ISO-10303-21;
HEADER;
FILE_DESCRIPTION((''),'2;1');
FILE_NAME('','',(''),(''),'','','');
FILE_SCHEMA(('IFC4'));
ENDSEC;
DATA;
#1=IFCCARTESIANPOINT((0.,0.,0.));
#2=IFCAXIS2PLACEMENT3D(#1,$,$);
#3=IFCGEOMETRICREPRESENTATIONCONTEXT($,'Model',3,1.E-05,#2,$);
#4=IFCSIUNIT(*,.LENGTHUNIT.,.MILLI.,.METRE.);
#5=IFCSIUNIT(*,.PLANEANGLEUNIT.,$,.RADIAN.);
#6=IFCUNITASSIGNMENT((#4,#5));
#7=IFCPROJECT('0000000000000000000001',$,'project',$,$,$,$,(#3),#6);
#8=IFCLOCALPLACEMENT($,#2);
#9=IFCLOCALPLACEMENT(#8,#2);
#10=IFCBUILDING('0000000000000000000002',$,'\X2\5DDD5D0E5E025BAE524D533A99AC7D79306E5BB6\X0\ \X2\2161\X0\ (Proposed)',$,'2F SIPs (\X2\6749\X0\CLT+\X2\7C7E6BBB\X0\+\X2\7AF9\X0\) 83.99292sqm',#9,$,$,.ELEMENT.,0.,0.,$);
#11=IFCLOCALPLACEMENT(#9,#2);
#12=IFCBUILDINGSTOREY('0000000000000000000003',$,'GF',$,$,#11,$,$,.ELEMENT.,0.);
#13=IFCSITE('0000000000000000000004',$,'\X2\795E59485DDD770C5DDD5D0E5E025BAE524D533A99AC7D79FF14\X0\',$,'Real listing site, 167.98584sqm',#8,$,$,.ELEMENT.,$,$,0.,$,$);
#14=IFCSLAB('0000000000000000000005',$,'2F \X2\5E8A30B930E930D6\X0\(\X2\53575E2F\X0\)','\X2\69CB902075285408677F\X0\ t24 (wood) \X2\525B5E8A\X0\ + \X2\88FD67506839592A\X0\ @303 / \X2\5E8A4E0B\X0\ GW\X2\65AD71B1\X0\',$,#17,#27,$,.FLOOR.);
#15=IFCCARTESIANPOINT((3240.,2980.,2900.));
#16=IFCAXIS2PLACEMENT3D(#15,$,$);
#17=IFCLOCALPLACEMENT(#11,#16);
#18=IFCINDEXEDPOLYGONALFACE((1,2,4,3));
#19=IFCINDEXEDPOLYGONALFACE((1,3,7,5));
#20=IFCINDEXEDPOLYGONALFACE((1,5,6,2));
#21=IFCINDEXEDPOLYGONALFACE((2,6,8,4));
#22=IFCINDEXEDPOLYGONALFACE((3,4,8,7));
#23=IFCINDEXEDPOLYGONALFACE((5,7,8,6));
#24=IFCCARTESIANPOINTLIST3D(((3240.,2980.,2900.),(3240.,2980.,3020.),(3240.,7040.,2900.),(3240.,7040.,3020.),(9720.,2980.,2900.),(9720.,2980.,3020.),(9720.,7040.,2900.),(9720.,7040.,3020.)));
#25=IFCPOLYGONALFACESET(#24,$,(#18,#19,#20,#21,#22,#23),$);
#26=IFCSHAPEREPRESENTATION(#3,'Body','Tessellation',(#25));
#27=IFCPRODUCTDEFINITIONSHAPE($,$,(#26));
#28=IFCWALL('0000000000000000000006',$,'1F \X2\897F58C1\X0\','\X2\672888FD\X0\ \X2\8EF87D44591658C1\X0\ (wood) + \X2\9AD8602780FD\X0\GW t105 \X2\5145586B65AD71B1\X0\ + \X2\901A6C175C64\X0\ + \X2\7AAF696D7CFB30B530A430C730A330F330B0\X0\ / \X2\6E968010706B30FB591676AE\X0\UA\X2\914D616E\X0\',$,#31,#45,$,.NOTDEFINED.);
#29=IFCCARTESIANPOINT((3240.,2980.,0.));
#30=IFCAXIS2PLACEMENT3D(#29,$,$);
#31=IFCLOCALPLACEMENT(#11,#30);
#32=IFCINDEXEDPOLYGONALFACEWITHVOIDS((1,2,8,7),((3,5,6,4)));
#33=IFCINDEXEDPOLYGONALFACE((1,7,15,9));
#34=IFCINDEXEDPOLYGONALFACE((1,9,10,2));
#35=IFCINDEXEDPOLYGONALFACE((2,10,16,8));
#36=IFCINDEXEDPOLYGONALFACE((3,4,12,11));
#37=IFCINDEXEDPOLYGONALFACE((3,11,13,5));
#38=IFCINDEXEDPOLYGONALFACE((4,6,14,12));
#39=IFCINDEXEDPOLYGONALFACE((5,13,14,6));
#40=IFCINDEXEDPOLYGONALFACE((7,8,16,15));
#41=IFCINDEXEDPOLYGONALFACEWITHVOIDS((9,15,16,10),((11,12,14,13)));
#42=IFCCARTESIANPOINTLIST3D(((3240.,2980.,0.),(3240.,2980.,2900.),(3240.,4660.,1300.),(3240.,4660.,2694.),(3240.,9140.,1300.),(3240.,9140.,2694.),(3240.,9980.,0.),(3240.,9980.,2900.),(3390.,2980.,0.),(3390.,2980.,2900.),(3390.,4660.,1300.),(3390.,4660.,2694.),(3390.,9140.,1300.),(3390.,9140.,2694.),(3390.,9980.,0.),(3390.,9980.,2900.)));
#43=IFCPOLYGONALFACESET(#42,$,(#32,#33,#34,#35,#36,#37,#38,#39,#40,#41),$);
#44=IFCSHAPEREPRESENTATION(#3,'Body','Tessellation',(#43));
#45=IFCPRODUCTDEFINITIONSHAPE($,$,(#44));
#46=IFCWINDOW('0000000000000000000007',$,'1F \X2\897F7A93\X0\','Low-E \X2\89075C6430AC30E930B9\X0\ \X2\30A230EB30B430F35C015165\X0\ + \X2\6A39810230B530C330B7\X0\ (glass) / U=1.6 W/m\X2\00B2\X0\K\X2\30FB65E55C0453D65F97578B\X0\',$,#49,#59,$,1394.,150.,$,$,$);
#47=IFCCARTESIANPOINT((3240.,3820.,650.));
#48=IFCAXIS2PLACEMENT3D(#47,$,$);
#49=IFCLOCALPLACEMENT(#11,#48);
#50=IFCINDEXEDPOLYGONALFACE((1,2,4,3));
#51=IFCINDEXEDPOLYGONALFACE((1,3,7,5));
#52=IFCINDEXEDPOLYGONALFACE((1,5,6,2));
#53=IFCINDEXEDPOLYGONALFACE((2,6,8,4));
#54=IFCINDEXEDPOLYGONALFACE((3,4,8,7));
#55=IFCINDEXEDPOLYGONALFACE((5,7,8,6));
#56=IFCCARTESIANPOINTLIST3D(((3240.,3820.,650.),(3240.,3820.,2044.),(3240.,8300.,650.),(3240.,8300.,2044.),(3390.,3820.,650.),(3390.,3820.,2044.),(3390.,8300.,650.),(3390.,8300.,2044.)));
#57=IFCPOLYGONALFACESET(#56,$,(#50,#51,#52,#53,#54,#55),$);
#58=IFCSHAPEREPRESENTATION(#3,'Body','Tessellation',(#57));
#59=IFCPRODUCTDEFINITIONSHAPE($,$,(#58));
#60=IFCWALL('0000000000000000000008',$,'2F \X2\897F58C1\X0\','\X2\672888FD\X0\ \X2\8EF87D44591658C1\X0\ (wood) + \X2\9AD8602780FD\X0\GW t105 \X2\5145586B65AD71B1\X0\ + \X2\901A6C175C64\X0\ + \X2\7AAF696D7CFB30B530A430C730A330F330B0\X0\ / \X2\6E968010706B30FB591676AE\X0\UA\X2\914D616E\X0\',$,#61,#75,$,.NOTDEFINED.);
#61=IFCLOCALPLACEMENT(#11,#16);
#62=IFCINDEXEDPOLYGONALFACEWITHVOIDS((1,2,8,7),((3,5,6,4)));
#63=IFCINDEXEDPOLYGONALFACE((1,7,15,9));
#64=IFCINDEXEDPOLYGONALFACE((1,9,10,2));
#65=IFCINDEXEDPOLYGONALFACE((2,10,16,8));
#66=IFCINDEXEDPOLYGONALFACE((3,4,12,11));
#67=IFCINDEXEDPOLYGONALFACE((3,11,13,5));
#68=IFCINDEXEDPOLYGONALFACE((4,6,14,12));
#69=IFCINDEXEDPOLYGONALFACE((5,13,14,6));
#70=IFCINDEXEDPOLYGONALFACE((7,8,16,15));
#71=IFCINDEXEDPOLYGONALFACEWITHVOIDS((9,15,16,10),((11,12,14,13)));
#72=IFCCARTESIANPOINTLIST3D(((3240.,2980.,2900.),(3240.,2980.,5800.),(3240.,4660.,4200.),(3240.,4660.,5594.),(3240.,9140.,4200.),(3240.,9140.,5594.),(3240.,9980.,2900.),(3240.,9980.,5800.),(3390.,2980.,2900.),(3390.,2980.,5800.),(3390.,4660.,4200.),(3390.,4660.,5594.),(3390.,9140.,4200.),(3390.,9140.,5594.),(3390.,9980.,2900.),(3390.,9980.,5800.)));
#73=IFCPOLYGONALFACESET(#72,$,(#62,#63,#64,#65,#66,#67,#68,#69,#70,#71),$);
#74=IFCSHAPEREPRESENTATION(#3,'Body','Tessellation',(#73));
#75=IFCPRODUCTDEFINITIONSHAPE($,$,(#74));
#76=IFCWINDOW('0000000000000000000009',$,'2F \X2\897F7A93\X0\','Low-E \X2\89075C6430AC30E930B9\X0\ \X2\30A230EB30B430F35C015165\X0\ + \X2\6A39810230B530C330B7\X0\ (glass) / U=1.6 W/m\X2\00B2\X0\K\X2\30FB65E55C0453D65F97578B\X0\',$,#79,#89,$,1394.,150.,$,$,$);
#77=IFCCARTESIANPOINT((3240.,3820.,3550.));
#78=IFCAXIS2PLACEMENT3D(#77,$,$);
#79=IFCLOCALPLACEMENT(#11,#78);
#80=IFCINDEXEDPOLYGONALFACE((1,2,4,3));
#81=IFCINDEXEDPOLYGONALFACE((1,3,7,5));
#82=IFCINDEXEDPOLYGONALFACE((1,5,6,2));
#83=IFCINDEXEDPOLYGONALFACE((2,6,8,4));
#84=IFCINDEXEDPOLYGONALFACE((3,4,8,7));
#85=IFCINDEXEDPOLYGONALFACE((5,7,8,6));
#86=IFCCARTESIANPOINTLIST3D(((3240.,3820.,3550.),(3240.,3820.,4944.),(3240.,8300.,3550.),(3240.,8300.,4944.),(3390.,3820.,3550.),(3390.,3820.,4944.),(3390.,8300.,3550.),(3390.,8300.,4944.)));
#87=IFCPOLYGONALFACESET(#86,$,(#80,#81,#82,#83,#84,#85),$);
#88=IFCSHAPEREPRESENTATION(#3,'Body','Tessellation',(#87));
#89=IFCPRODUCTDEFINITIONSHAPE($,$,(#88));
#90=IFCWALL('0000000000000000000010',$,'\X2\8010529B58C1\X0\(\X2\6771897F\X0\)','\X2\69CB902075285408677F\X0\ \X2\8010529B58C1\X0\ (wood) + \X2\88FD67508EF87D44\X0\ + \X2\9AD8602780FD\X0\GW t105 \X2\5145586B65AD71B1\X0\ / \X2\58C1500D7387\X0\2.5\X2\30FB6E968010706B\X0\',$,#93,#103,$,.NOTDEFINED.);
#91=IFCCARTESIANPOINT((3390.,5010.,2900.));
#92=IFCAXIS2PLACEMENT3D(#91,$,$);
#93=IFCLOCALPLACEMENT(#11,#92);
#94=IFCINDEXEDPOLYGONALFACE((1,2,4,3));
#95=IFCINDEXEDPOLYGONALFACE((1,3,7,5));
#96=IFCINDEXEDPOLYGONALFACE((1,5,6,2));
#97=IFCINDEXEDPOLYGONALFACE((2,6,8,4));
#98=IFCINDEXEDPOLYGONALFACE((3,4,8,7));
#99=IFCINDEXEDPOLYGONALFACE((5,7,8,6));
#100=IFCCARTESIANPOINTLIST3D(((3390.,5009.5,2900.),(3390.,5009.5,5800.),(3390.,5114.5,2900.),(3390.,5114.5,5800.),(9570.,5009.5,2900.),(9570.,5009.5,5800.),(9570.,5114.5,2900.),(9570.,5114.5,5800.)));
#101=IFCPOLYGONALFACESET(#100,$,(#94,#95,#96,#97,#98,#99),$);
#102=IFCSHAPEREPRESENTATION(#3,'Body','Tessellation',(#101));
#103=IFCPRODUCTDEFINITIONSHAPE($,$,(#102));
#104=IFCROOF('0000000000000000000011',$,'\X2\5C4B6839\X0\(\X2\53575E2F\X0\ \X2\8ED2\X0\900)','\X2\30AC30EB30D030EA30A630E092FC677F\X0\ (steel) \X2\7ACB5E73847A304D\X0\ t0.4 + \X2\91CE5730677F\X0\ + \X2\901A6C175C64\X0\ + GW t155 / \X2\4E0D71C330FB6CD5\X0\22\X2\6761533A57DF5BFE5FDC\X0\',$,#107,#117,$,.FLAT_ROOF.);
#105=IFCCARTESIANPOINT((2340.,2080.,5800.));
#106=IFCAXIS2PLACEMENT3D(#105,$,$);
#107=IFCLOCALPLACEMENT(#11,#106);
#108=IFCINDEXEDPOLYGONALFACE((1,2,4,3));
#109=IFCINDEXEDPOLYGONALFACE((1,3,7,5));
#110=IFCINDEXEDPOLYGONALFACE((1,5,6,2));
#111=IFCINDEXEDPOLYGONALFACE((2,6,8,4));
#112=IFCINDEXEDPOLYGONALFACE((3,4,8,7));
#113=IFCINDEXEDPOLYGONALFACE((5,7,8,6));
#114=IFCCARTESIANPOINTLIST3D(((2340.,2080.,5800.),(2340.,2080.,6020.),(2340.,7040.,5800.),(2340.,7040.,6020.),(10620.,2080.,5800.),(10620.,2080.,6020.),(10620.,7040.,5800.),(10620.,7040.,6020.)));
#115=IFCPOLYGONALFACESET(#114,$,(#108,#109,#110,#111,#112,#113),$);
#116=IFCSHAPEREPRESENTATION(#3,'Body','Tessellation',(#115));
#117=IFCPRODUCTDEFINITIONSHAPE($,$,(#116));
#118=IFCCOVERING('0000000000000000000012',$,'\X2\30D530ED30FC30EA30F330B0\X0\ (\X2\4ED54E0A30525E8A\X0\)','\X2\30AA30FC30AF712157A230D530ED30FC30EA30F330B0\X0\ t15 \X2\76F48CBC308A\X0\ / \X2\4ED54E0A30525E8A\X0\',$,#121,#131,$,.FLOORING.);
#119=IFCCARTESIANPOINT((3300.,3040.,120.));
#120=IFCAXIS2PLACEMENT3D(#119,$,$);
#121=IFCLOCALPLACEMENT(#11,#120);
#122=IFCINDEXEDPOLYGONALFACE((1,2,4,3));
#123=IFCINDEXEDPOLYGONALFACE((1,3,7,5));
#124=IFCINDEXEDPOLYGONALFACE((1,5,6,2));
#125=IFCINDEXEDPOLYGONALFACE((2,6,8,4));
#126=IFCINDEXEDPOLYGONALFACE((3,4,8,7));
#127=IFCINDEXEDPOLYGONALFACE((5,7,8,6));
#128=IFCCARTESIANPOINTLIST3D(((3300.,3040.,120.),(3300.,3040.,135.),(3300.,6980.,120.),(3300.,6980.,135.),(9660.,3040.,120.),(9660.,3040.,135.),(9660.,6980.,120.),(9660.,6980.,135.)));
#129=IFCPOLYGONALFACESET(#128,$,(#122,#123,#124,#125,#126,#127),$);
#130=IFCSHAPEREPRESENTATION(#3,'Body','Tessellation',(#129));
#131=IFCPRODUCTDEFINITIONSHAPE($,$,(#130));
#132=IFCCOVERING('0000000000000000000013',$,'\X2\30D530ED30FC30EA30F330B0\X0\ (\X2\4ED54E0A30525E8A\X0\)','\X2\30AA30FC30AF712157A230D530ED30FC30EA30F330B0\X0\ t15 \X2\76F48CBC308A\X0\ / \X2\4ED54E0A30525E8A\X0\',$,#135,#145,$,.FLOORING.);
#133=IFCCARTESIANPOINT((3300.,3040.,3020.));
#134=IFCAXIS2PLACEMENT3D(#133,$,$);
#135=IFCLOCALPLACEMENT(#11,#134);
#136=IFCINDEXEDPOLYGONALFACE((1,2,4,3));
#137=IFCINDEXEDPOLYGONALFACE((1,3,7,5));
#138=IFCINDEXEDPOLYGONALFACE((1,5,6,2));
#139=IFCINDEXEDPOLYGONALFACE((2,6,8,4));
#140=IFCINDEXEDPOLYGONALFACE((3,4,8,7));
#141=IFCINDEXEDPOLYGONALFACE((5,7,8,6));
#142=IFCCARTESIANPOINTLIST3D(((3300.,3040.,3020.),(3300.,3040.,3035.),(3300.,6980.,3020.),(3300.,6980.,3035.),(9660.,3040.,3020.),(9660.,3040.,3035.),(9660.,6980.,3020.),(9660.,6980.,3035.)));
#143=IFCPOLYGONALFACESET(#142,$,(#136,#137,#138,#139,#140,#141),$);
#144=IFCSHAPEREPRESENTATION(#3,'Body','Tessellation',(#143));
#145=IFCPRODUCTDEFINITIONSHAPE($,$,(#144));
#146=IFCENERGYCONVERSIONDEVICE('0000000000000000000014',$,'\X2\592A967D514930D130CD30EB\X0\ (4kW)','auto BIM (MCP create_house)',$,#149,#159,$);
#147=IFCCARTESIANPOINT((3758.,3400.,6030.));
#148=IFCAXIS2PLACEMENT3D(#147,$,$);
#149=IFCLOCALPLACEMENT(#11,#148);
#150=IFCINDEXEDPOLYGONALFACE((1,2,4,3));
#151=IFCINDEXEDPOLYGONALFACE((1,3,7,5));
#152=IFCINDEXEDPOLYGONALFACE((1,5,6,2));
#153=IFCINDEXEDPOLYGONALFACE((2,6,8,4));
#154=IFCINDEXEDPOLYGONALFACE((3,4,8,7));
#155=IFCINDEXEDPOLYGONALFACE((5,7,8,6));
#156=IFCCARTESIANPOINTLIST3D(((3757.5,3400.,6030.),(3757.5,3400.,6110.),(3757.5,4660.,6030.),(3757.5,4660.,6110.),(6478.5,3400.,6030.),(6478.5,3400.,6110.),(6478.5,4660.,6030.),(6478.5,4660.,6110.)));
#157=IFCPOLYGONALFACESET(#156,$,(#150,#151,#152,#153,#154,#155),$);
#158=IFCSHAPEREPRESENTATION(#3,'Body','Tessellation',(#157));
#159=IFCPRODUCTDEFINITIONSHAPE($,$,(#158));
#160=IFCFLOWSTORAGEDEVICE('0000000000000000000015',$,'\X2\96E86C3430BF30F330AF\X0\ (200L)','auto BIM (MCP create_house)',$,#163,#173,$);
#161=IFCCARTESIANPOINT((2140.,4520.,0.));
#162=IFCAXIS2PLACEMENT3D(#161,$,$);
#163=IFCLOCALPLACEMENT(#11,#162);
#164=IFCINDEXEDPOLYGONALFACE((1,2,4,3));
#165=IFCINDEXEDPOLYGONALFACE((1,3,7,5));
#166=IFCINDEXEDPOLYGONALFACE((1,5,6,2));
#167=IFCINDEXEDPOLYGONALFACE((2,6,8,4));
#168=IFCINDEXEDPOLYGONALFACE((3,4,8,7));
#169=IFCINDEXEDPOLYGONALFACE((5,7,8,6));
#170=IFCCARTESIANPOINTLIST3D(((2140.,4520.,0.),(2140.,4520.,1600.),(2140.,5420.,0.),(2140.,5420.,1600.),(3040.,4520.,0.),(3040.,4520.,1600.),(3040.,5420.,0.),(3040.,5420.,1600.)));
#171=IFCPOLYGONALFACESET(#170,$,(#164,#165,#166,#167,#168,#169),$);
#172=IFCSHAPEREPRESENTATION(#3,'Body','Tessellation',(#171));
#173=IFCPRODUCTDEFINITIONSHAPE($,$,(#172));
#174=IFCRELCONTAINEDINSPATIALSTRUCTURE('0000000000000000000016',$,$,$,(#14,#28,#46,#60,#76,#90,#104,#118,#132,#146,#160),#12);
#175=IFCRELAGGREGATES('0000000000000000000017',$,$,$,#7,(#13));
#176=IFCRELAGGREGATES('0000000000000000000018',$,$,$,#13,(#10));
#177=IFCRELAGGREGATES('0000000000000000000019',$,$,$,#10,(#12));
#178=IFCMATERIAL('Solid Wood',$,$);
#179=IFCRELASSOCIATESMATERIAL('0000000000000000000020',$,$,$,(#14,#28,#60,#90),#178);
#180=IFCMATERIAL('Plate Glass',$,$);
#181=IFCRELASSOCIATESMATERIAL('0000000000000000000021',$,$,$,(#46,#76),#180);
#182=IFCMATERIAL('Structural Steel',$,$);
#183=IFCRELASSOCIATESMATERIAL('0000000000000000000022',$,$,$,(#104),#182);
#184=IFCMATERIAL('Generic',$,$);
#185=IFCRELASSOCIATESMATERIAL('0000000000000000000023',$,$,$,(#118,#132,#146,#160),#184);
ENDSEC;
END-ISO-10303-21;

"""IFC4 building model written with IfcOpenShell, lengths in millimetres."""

from ifc_helpers import new_model, si_unit, frame, frame_2d, origin, place, context, project, spatial, rectangle, extrude, material, element, fill, save


model = new_model("IFC4")

# Units and contexts
model_context = context("Model", 3, precision=1e-05, world=origin())
ifc_project = project(units=[si_unit("LENGTHUNIT", "METRE", prefix="MILLI"), si_unit("PLANEANGLEUNIT", "RADIAN")], contexts=[model_context])

# Site, building, storey
site_placement = place(None, origin())
site = spatial("IfcSite", under=ifc_project, at=site_placement, Name="神奈川県川崎市宮前区馬絹４", ObjectType="Real listing site, 167.98584sqm", CompositionType="ELEMENT", RefElevation=0.0)
building_placement = place(site_placement, origin())
building = spatial("IfcBuilding", under=site, at=building_placement, Name="川崎市宮前区馬絹の家 Ⅱ (Proposed)", ObjectType="2F SIPs (杉CLT+籾殻+竹) 83.99292sqm", CompositionType="ELEMENT", ElevationOfRefHeight=0.0, ElevationOfTerrain=0.0)
storey_placement = place(building_placement, origin())
storey = spatial("IfcBuildingStorey", under=building, at=storey_placement, Name="GF", CompositionType="ELEMENT", Elevation=0.0)

# Slab
ifc_material_1 = material(Name="Solid Wood")
slab_1_placement = place(storey_placement, frame((3240.0, 2980.0, 2900.0)))
element("IfcSlab", 1, at=slab_1_placement, inside=storey, material=ifc_material_1, Name="2F 床スラブ(南帯)", Description="構造用合板 t24 (wood) 剛床 + 製材根太 @303 / 床下 GW断熱", PredefinedType="FLOOR", context=model_context, shape_type="SweptSolid", body=[
    extrude(rectangle(XDim=6480.0, YDim=4060.0, at=frame_2d((3240.0, 2030.0))), frame((3240.0, 2980.0, 2900.0)), (0.0, 0.0, 1.0), 120.0),
])

# Shared definitions
ifc_material_2 = material(Name="Plate Glass")

# Wall, opening, window
wall_1_placement = place(storey_placement, frame((3240.0, 2980.0, 0.0)))
wall_1 = element("IfcWall", 2, at=wall_1_placement, inside=storey, material=ifc_material_1, Name="1F 西壁", Description="木製 軸組外壁 (wood) + 高性能GW t105 充填断熱 + 通気層 + 窯業系サイディング / 準耐火・外皮UA配慮", PredefinedType="NOTDEFINED", context=model_context, shape_type="SweptSolid", body=[
    extrude(rectangle(XDim=150.0, YDim=7000.0, at=frame_2d((75.0, 3500.0))), frame((3240.0, 2980.0, 0.0)), (0.0, 0.0, 1.0), 2900.0),
])
opening_1_placement = place(storey_placement, frame((3240.0, 3820.0, 650.0)))
opening_1 = element("IfcOpeningElement", 3, at=opening_1_placement, cuts=wall_1, PredefinedType="NOTDEFINED", context=model_context, shape_type="SweptSolid", body=[
    extrude(rectangle(XDim=150.0, YDim=4480.0, at=frame_2d((75.0, 2240.0))), frame((3240.0, 3820.0, 650.0)), (0.0, 0.0, 1.0), 1394.0),
])
window_1_placement = place(storey_placement, frame((3240.0, 3820.0, 650.0)))
window_1 = element("IfcWindow", 4, at=window_1_placement, inside=storey, material=ifc_material_2, Name="1F 西窓", Description="Low-E 複層ガラス アルゴン封入 + 樹脂サッシ (glass) / U=1.6 W/m²K・日射取得型", OverallHeight=1394.0, OverallWidth=150.0, context=model_context, shape_type="SweptSolid", body=[
    extrude(rectangle(XDim=150.0, YDim=4480.0, at=frame_2d((75.0, 2240.0))), frame((3240.0, 3820.0, 650.0)), (0.0, 0.0, 1.0), 1394.0),
])
fill(opening_1, window_1)

# Wall, opening, window
wall_2_placement = place(storey_placement, frame((3240.0, 2980.0, 2900.0)))
wall_2 = element("IfcWall", 5, at=wall_2_placement, inside=storey, material=ifc_material_1, Name="2F 西壁", Description="木製 軸組外壁 (wood) + 高性能GW t105 充填断熱 + 通気層 + 窯業系サイディング / 準耐火・外皮UA配慮", PredefinedType="NOTDEFINED", context=model_context, shape_type="SweptSolid", body=[
    extrude(rectangle(XDim=150.0, YDim=7000.0, at=frame_2d((75.0, 3500.0))), frame((3240.0, 2980.0, 2900.0)), (0.0, 0.0, 1.0), 2900.0),
])
opening_2_placement = place(storey_placement, frame((3240.0, 3820.0, 3550.0)))
opening_2 = element("IfcOpeningElement", 6, at=opening_2_placement, cuts=wall_2, PredefinedType="NOTDEFINED", context=model_context, shape_type="SweptSolid", body=[
    extrude(rectangle(XDim=150.0, YDim=4480.0, at=frame_2d((75.0, 2240.0))), frame((3240.0, 3820.0, 3550.0)), (0.0, 0.0, 1.0), 1394.0),
])
window_2_placement = place(storey_placement, frame((3240.0, 3820.0, 3550.0)))
window_2 = element("IfcWindow", 7, at=window_2_placement, inside=storey, material=ifc_material_2, Name="2F 西窓", Description="Low-E 複層ガラス アルゴン封入 + 樹脂サッシ (glass) / U=1.6 W/m²K・日射取得型", OverallHeight=1394.0, OverallWidth=150.0, context=model_context, shape_type="SweptSolid", body=[
    extrude(rectangle(XDim=150.0, YDim=4480.0, at=frame_2d((75.0, 2240.0))), frame((3240.0, 3820.0, 3550.0)), (0.0, 0.0, 1.0), 1394.0),
])
fill(opening_2, window_2)

# Wall
wall_3_placement = place(storey_placement, frame((3390.0, 5010.0, 2900.0)))
element("IfcWall", 8, at=wall_3_placement, inside=storey, material=ifc_material_1, Name="耐力壁(東西)", Description="構造用合板 耐力壁 (wood) + 製材軸組 + 高性能GW t105 充填断熱 / 壁倍率2.5・準耐火", PredefinedType="NOTDEFINED", context=model_context, shape_type="SweptSolid", body=[
    extrude(rectangle(XDim=6180.0, YDim=105.0, at=frame_2d((3090.0, 52.0))), frame((3390.0, 5010.0, 2900.0)), (0.0, 0.0, 1.0), 2900.0),
])

# Roof
ifc_material_3 = material(Name="Structural Steel")
for number, where, name in (
    (9, (2340.0, 2080.0, 5800.0), "屋根(南帯 軒900)"),
):
    element("IfcRoof", number, at=place(storey_placement, frame(where)), inside=storey, material=ifc_material_3, Name=name, Description="ガルバリウム鋼板 (steel) 立平葺き t0.4 + 野地板 + 通気層 + GW t155 / 不燃・法22条区域対応", PredefinedType="FLAT_ROOF", context=model_context, shape_type="SweptSolid", body=[
        extrude(rectangle(XDim=8280.0, YDim=4960.0, at=frame_2d((4140.0, 2480.0))), frame((2340.0, 2080.0, 5800.0)), (0.0, 0.0, 1.0), 220.0),
    ])

# Coverings
ifc_material_4 = material(Name="Generic")
covering_1_placement = place(storey_placement, frame((3300.0, 3040.0, 120.0)))
element("IfcCovering", 10, at=covering_1_placement, inside=storey, material=ifc_material_4, Name="フローリング (仕上げ床)", Description="オーク無垢フローリング t15 直貼り / 仕上げ床", PredefinedType="FLOORING", context=model_context, shape_type="SweptSolid", body=[
    extrude(rectangle(XDim=6360.0, YDim=3940.0, at=frame_2d((3180.0, 1970.0))), frame((3300.0, 3040.0, 120.0)), (0.0, 0.0, 1.0), 15.0),
])
covering_2_placement = place(storey_placement, frame((3300.0, 3040.0, 3020.0)))
element("IfcCovering", 11, at=covering_2_placement, inside=storey, material=ifc_material_4, Name="フローリング (仕上げ床)", Description="オーク無垢フローリング t15 直貼り / 仕上げ床", PredefinedType="FLOORING", context=model_context, shape_type="SweptSolid", body=[
    extrude(rectangle(XDim=6360.0, YDim=3940.0, at=frame_2d((3180.0, 1970.0))), frame((3300.0, 3040.0, 3020.0)), (0.0, 0.0, 1.0), 15.0),
])

# Energy conversion device
energy_conversion_device_placement = place(storey_placement, frame((3758.0, 3400.0, 6030.0)))
element("IfcEnergyConversionDevice", 12, at=energy_conversion_device_placement, inside=storey, material=ifc_material_4, Name="太陽光パネル (4kW)", Description="auto BIM (MCP create_house)", context=model_context, shape_type="SweptSolid", body=[
    extrude(rectangle(XDim=2721.0, YDim=1260.0, at=frame_2d((1360.0, 630.0))), frame((3758.0, 3400.0, 6030.0)), (0.0, 0.0, 1.0), 80.0),
])

# Flow storage device
flow_storage_device_placement = place(storey_placement, frame((2140.0, 4520.0, 0.0)))
element("IfcFlowStorageDevice", 13, at=flow_storage_device_placement, inside=storey, material=ifc_material_4, Name="雨水タンク (200L)", Description="auto BIM (MCP create_house)", context=model_context, shape_type="SweptSolid", body=[
    extrude(rectangle(XDim=900.0, YDim=900.0, at=frame_2d((450.0, 450.0))), frame((2140.0, 4520.0, 0.0)), (0.0, 0.0, 1.0), 1600.0),
])

save(model, "model.ifc")
